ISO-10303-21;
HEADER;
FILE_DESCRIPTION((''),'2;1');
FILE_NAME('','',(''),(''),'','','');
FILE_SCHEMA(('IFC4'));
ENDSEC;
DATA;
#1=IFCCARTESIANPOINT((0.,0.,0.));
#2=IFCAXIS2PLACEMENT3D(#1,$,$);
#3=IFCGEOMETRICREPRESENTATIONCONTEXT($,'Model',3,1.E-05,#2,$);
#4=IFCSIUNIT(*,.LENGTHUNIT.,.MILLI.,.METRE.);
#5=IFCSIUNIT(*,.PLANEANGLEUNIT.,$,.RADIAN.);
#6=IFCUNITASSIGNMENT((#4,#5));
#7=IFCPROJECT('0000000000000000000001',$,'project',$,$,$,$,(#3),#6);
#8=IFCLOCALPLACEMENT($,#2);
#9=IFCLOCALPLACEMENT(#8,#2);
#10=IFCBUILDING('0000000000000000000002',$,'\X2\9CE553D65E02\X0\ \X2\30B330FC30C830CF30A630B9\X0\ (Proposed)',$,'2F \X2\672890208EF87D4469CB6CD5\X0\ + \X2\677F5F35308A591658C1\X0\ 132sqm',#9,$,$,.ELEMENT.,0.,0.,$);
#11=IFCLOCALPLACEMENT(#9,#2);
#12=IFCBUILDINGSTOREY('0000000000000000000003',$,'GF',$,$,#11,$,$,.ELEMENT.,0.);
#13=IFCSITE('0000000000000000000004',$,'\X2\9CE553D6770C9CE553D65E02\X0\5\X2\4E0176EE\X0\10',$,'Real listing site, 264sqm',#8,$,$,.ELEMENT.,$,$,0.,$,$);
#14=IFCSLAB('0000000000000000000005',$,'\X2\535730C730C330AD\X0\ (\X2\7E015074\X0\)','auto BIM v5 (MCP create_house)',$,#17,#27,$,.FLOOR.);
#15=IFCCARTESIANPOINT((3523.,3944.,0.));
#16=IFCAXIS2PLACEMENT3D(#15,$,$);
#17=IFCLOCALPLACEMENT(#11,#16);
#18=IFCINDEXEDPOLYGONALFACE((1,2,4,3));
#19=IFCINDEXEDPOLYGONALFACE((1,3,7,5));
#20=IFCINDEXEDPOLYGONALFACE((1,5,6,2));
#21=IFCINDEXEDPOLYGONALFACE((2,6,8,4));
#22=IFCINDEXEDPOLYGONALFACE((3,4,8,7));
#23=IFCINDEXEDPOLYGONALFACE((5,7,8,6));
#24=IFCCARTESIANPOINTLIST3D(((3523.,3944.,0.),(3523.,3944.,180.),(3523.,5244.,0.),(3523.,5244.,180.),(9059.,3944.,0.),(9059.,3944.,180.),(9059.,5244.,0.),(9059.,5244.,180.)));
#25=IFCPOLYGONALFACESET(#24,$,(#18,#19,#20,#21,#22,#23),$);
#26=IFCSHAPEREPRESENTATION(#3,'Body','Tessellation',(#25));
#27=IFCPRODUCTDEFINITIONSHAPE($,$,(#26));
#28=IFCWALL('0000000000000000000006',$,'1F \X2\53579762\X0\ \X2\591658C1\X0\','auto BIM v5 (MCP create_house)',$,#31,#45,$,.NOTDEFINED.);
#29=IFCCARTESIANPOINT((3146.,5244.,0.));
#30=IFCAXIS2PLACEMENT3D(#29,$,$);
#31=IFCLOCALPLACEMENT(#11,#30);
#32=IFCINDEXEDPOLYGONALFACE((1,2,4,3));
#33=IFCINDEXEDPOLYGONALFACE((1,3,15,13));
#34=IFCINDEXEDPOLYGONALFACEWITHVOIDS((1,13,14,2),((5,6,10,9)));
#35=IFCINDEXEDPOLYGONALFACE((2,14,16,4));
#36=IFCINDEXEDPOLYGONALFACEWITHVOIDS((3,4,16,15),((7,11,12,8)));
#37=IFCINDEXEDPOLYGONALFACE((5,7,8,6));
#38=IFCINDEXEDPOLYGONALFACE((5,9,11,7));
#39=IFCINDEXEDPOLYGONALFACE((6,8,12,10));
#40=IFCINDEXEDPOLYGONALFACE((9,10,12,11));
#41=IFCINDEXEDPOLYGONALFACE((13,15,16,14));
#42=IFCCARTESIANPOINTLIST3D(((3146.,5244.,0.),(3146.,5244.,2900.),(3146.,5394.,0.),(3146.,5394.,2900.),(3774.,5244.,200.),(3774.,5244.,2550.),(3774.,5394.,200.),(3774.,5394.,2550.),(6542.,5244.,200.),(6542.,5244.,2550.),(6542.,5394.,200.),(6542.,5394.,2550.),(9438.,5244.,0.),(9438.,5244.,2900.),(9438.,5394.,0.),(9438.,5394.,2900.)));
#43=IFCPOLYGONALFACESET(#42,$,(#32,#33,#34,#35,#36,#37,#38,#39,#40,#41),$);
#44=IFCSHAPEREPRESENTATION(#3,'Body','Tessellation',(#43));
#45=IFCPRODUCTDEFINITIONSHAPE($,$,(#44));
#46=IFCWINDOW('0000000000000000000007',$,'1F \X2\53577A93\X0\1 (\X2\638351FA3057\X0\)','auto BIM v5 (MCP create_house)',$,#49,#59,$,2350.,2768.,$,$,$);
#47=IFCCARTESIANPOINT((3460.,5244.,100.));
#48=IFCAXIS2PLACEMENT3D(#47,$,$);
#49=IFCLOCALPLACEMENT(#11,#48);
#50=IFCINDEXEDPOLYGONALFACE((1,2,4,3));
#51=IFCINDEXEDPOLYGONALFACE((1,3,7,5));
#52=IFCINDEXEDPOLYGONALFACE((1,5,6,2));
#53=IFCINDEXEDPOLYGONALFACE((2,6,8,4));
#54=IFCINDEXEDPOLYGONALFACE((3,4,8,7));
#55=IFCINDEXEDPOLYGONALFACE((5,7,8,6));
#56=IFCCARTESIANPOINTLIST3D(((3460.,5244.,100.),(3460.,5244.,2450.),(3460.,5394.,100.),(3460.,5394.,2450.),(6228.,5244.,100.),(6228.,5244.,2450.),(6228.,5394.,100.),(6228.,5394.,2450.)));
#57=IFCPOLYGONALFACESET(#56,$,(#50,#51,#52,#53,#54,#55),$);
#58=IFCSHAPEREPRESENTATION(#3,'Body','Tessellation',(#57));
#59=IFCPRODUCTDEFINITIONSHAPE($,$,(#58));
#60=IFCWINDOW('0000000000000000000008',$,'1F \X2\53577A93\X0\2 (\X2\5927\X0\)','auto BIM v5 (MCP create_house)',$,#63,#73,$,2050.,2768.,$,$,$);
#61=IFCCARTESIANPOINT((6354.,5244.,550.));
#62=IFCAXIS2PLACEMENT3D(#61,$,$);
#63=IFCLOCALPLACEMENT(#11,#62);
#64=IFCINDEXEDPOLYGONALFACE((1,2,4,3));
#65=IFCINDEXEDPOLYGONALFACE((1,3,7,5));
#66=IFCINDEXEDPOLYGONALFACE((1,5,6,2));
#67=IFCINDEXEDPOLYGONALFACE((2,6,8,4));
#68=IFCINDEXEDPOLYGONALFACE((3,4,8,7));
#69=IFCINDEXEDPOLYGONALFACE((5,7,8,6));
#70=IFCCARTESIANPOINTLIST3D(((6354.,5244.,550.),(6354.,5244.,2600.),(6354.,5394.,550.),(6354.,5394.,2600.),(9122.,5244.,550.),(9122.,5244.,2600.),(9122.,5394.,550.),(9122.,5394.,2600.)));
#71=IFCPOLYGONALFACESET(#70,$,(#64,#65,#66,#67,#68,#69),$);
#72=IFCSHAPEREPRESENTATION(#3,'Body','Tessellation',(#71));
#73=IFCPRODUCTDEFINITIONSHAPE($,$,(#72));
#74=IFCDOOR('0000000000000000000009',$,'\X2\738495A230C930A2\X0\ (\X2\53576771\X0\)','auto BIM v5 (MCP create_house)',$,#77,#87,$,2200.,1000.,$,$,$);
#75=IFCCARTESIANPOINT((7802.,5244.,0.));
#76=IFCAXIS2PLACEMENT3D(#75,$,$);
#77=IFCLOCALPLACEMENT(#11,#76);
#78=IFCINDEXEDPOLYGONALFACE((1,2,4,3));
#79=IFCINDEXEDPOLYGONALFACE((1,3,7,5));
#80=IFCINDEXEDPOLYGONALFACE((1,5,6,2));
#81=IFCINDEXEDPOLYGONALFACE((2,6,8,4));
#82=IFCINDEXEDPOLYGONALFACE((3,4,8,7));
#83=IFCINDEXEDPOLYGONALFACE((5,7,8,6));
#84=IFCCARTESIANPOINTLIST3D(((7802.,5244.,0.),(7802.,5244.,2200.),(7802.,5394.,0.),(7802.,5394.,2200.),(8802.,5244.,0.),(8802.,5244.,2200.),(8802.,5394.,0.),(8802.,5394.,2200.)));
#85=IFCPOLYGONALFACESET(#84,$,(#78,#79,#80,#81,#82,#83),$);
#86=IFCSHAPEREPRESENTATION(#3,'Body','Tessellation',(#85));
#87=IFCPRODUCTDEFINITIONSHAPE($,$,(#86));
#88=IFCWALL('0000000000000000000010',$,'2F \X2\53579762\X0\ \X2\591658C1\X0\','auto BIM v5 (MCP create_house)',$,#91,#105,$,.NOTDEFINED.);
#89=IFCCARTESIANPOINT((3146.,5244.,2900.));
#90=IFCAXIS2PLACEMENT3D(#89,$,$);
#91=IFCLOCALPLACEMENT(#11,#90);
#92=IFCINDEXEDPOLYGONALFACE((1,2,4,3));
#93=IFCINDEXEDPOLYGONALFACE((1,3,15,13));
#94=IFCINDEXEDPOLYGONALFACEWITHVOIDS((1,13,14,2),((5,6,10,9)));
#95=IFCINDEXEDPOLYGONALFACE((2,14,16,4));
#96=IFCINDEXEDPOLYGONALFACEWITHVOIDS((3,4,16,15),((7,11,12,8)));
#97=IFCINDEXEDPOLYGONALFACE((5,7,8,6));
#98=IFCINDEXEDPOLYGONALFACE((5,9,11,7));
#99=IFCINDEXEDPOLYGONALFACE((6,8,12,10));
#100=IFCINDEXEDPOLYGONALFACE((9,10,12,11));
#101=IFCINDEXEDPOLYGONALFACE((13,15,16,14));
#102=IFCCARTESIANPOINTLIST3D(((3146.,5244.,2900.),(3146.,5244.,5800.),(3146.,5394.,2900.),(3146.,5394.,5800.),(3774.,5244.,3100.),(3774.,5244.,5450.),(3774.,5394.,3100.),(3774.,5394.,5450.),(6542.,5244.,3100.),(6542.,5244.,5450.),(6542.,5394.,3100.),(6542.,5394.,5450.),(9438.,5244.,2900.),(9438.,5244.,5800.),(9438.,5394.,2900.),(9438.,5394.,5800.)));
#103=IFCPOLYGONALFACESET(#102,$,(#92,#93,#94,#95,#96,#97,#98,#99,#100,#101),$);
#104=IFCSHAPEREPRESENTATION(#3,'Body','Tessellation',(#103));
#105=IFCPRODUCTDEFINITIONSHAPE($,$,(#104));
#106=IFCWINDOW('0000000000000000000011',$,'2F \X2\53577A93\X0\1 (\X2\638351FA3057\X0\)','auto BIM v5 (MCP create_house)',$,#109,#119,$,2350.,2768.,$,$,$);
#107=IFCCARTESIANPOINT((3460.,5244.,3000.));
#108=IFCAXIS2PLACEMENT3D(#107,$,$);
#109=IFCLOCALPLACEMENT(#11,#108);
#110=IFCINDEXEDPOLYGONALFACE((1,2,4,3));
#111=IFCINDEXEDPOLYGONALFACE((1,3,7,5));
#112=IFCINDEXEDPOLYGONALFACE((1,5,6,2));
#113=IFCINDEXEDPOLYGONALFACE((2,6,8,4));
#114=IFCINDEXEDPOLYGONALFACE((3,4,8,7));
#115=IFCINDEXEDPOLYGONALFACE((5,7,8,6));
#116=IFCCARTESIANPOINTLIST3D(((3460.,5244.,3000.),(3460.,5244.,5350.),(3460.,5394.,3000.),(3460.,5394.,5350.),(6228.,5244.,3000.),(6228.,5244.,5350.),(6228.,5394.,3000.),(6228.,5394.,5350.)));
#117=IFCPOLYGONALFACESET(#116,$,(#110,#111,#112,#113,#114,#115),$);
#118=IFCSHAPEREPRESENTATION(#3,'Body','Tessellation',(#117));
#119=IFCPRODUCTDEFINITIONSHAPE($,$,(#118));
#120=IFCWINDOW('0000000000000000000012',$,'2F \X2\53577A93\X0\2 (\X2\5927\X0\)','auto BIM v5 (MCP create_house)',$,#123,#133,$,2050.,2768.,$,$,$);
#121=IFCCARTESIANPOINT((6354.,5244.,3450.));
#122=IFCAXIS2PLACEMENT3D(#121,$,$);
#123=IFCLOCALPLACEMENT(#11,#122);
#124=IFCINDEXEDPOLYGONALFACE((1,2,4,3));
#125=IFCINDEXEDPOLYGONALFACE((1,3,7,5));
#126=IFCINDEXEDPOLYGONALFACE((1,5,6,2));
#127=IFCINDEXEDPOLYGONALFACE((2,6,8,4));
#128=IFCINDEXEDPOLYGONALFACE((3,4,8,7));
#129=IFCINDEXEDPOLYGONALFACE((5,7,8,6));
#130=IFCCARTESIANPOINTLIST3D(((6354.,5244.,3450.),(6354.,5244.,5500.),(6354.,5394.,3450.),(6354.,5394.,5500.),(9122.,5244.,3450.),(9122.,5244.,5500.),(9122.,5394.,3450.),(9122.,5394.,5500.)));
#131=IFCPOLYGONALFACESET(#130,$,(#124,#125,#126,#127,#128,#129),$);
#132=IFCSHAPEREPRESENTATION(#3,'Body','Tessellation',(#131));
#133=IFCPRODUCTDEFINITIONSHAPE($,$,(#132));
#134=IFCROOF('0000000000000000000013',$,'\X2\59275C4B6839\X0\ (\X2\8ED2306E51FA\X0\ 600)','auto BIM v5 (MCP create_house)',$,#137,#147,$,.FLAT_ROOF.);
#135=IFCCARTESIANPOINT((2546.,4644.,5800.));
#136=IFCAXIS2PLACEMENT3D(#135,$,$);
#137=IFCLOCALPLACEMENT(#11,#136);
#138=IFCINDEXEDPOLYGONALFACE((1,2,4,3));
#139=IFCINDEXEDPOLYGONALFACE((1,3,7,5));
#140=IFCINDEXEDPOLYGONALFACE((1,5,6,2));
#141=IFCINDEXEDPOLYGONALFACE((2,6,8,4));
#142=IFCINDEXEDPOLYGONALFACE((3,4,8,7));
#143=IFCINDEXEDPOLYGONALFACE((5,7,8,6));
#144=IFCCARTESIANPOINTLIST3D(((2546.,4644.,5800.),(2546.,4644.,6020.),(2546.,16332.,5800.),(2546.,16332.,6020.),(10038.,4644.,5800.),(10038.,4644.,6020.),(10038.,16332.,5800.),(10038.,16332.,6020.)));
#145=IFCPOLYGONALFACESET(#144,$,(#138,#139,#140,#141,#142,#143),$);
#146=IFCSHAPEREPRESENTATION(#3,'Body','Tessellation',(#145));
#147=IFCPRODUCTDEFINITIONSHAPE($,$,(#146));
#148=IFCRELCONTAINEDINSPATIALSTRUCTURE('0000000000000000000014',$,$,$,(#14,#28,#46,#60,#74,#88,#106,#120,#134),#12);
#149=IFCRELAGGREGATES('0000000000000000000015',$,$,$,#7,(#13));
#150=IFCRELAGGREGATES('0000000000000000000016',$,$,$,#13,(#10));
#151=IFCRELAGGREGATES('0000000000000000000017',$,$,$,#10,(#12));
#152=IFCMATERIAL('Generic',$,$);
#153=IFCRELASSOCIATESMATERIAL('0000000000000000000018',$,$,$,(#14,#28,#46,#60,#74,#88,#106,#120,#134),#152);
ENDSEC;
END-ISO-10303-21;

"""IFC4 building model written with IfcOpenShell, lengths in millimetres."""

from ifc_helpers import new_model, si_unit, frame, frame_2d, origin, place, context, project, spatial, rectangle, extrude, material, element, fill, save


model = new_model("IFC4")

# Units and contexts
model_context = context("Model", 3, precision=1e-05, world=origin())
ifc_project = project(units=[si_unit("LENGTHUNIT", "METRE", prefix="MILLI"), si_unit("PLANEANGLEUNIT", "RADIAN")], contexts=[model_context])

# Site, building, storey
site_placement = place(None, origin())
site = spatial("IfcSite", under=ifc_project, at=site_placement, Name="鳥取県鳥取市5丁目10", ObjectType="Real listing site, 264sqm", CompositionType="ELEMENT", RefElevation=0.0)
building_placement = place(site_placement, origin())
building = spatial("IfcBuilding", under=site, at=building_placement, Name="鳥取市 コートハウス (Proposed)", ObjectType="2F 木造軸組構法 + 板張り外壁 132sqm", CompositionType="ELEMENT", ElevationOfRefHeight=0.0, ElevationOfTerrain=0.0)
storey_placement = place(building_placement, origin())
storey = spatial("IfcBuildingStorey", under=building, at=storey_placement, Name="GF", CompositionType="ELEMENT", Elevation=0.0)

# Slab
ifc_material = material(Name="Generic")
slab_1_placement = place(storey_placement, frame((3523.0, 3944.0, 0.0)))
element("IfcSlab", 1, at=slab_1_placement, inside=storey, material=ifc_material, Name="南デッキ (縁側)", Description="auto BIM v5 (MCP create_house)", PredefinedType="FLOOR", context=model_context, shape_type="SweptSolid", body=[
    extrude(rectangle(XDim=5536.0, YDim=1300.0, at=frame_2d((2768.0, 650.0))), frame((3523.0, 3944.0, 0.0)), (0.0, 0.0, 1.0), 180.0),
])

# Wall, openings, windows, door
wall_1_placement = place(storey_placement, frame((3146.0, 5244.0, 0.0)))
wall_1 = element("IfcWall", 2, at=wall_1_placement, inside=storey, material=ifc_material, Name="1F 南面 外壁", Description="auto BIM v5 (MCP create_house)", PredefinedType="NOTDEFINED", context=model_context, shape_type="SweptSolid", body=[
    extrude(rectangle(XDim=6292.0, YDim=150.0, at=frame_2d((3146.0, 75.0))), frame((3146.0, 5244.0, 0.0)), (0.0, 0.0, 1.0), 2900.0),
])
opening_1_placement = place(storey_placement, frame((3460.0, 5244.0, 100.0)))
opening_1 = element("IfcOpeningElement", 3, at=opening_1_placement, cuts=wall_1, PredefinedType="NOTDEFINED", context=model_context, shape_type="SweptSolid", body=[
    extrude(rectangle(XDim=2768.0, YDim=150.0, at=frame_2d((1384.0, 75.0))), frame((3460.0, 5244.0, 100.0)), (0.0, 0.0, 1.0), 2350.0),
])
opening_2_placement = place(storey_placement, frame((6354.0, 5244.0, 550.0)))
opening_2 = element("IfcOpeningElement", 4, at=opening_2_placement, cuts=wall_1, PredefinedType="NOTDEFINED", context=model_context, shape_type="SweptSolid", body=[
    extrude(rectangle(XDim=2768.0, YDim=150.0, at=frame_2d((1384.0, 75.0))), frame((6354.0, 5244.0, 550.0)), (0.0, 0.0, 1.0), 2050.0),
])
opening_3_placement = place(storey_placement, frame((7802.0, 5244.0, 0.0)))
opening_3 = element("IfcOpeningElement", 5, at=opening_3_placement, cuts=wall_1, PredefinedType="NOTDEFINED", context=model_context, shape_type="SweptSolid", body=[
    extrude(rectangle(XDim=1000.0, YDim=150.0, at=frame_2d((500.0, 75.0))), frame((7802.0, 5244.0, 0.0)), (0.0, 0.0, 1.0), 2200.0),
])
window_1_placement = place(storey_placement, frame((3460.0, 5244.0, 100.0)))
window_1 = element("IfcWindow", 6, at=window_1_placement, inside=storey, material=ifc_material, Name="1F 南窓1 (掃出し)", Description="auto BIM v5 (MCP create_house)", OverallHeight=2350.0, OverallWidth=2768.0, context=model_context, shape_type="SweptSolid", body=[
    extrude(rectangle(XDim=2768.0, YDim=150.0, at=frame_2d((1384.0, 75.0))), frame((3460.0, 5244.0, 100.0)), (0.0, 0.0, 1.0), 2350.0),
])
fill(opening_1, window_1)
window_2_placement = place(storey_placement, frame((6354.0, 5244.0, 550.0)))
window_2 = element("IfcWindow", 7, at=window_2_placement, inside=storey, material=ifc_material, Name="1F 南窓2 (大)", Description="auto BIM v5 (MCP create_house)", OverallHeight=2050.0, OverallWidth=2768.0, context=model_context, shape_type="SweptSolid", body=[
    extrude(rectangle(XDim=2768.0, YDim=150.0, at=frame_2d((1384.0, 75.0))), frame((6354.0, 5244.0, 550.0)), (0.0, 0.0, 1.0), 2050.0),
])
fill(opening_2, window_2)
door_placement = place(storey_placement, frame((7802.0, 5244.0, 0.0)))
door = element("IfcDoor", 8, at=door_placement, inside=storey, material=ifc_material, Name="玄関ドア (南東)", Description="auto BIM v5 (MCP create_house)", OverallHeight=2200.0, OverallWidth=1000.0, context=model_context, shape_type="SweptSolid", body=[
    extrude(rectangle(XDim=1000.0, YDim=150.0, at=frame_2d((500.0, 75.0))), frame((7802.0, 5244.0, 0.0)), (0.0, 0.0, 1.0), 2200.0),
])
fill(opening_3, door)

# Wall, openings, windows
wall_2_placement = place(storey_placement, frame((3146.0, 5244.0, 2900.0)))
wall_2 = element("IfcWall", 9, at=wall_2_placement, inside=storey, material=ifc_material, Name="2F 南面 外壁", Description="auto BIM v5 (MCP create_house)", PredefinedType="NOTDEFINED", context=model_context, shape_type="SweptSolid", body=[
    extrude(rectangle(XDim=6292.0, YDim=150.0, at=frame_2d((3146.0, 75.0))), frame((3146.0, 5244.0, 2900.0)), (0.0, 0.0, 1.0), 2900.0),
])
opening_4_placement = place(storey_placement, frame((3460.0, 5244.0, 3000.0)))
opening_4 = element("IfcOpeningElement", 10, at=opening_4_placement, cuts=wall_2, PredefinedType="NOTDEFINED", context=model_context, shape_type="SweptSolid", body=[
    extrude(rectangle(XDim=2768.0, YDim=150.0, at=frame_2d((1384.0, 75.0))), frame((3460.0, 5244.0, 3000.0)), (0.0, 0.0, 1.0), 2350.0),
])
opening_5_placement = place(storey_placement, frame((6354.0, 5244.0, 3450.0)))
opening_5 = element("IfcOpeningElement", 11, at=opening_5_placement, cuts=wall_2, PredefinedType="NOTDEFINED", context=model_context, shape_type="SweptSolid", body=[
    extrude(rectangle(XDim=2768.0, YDim=150.0, at=frame_2d((1384.0, 75.0))), frame((6354.0, 5244.0, 3450.0)), (0.0, 0.0, 1.0), 2050.0),
])
window_3_placement = place(storey_placement, frame((3460.0, 5244.0, 3000.0)))
window_3 = element("IfcWindow", 12, at=window_3_placement, inside=storey, material=ifc_material, Name="2F 南窓1 (掃出し)", Description="auto BIM v5 (MCP create_house)", OverallHeight=2350.0, OverallWidth=2768.0, context=model_context, shape_type="SweptSolid", body=[
    extrude(rectangle(XDim=2768.0, YDim=150.0, at=frame_2d((1384.0, 75.0))), frame((3460.0, 5244.0, 3000.0)), (0.0, 0.0, 1.0), 2350.0),
])
fill(opening_4, window_3)
window_4_placement = place(storey_placement, frame((6354.0, 5244.0, 3450.0)))
window_4 = element("IfcWindow", 13, at=window_4_placement, inside=storey, material=ifc_material, Name="2F 南窓2 (大)", Description="auto BIM v5 (MCP create_house)", OverallHeight=2050.0, OverallWidth=2768.0, context=model_context, shape_type="SweptSolid", body=[
    extrude(rectangle(XDim=2768.0, YDim=150.0, at=frame_2d((1384.0, 75.0))), frame((6354.0, 5244.0, 3450.0)), (0.0, 0.0, 1.0), 2050.0),
])
fill(opening_5, window_4)

# Roof
roof_placement = place(storey_placement, frame((2546.0, 4644.0, 5800.0)))
element("IfcRoof", 14, at=roof_placement, inside=storey, material=ifc_material, Name="大屋根 (軒の出 600)", Description="auto BIM v5 (MCP create_house)", PredefinedType="FLAT_ROOF", context=model_context, shape_type="SweptSolid", body=[
    extrude(rectangle(XDim=7492.0, YDim=11688.0, at=frame_2d((3746.0, 5844.0))), frame((2546.0, 4644.0, 5800.0)), (0.0, 0.0, 1.0), 220.0),
])

save(model, "model.ifc")
